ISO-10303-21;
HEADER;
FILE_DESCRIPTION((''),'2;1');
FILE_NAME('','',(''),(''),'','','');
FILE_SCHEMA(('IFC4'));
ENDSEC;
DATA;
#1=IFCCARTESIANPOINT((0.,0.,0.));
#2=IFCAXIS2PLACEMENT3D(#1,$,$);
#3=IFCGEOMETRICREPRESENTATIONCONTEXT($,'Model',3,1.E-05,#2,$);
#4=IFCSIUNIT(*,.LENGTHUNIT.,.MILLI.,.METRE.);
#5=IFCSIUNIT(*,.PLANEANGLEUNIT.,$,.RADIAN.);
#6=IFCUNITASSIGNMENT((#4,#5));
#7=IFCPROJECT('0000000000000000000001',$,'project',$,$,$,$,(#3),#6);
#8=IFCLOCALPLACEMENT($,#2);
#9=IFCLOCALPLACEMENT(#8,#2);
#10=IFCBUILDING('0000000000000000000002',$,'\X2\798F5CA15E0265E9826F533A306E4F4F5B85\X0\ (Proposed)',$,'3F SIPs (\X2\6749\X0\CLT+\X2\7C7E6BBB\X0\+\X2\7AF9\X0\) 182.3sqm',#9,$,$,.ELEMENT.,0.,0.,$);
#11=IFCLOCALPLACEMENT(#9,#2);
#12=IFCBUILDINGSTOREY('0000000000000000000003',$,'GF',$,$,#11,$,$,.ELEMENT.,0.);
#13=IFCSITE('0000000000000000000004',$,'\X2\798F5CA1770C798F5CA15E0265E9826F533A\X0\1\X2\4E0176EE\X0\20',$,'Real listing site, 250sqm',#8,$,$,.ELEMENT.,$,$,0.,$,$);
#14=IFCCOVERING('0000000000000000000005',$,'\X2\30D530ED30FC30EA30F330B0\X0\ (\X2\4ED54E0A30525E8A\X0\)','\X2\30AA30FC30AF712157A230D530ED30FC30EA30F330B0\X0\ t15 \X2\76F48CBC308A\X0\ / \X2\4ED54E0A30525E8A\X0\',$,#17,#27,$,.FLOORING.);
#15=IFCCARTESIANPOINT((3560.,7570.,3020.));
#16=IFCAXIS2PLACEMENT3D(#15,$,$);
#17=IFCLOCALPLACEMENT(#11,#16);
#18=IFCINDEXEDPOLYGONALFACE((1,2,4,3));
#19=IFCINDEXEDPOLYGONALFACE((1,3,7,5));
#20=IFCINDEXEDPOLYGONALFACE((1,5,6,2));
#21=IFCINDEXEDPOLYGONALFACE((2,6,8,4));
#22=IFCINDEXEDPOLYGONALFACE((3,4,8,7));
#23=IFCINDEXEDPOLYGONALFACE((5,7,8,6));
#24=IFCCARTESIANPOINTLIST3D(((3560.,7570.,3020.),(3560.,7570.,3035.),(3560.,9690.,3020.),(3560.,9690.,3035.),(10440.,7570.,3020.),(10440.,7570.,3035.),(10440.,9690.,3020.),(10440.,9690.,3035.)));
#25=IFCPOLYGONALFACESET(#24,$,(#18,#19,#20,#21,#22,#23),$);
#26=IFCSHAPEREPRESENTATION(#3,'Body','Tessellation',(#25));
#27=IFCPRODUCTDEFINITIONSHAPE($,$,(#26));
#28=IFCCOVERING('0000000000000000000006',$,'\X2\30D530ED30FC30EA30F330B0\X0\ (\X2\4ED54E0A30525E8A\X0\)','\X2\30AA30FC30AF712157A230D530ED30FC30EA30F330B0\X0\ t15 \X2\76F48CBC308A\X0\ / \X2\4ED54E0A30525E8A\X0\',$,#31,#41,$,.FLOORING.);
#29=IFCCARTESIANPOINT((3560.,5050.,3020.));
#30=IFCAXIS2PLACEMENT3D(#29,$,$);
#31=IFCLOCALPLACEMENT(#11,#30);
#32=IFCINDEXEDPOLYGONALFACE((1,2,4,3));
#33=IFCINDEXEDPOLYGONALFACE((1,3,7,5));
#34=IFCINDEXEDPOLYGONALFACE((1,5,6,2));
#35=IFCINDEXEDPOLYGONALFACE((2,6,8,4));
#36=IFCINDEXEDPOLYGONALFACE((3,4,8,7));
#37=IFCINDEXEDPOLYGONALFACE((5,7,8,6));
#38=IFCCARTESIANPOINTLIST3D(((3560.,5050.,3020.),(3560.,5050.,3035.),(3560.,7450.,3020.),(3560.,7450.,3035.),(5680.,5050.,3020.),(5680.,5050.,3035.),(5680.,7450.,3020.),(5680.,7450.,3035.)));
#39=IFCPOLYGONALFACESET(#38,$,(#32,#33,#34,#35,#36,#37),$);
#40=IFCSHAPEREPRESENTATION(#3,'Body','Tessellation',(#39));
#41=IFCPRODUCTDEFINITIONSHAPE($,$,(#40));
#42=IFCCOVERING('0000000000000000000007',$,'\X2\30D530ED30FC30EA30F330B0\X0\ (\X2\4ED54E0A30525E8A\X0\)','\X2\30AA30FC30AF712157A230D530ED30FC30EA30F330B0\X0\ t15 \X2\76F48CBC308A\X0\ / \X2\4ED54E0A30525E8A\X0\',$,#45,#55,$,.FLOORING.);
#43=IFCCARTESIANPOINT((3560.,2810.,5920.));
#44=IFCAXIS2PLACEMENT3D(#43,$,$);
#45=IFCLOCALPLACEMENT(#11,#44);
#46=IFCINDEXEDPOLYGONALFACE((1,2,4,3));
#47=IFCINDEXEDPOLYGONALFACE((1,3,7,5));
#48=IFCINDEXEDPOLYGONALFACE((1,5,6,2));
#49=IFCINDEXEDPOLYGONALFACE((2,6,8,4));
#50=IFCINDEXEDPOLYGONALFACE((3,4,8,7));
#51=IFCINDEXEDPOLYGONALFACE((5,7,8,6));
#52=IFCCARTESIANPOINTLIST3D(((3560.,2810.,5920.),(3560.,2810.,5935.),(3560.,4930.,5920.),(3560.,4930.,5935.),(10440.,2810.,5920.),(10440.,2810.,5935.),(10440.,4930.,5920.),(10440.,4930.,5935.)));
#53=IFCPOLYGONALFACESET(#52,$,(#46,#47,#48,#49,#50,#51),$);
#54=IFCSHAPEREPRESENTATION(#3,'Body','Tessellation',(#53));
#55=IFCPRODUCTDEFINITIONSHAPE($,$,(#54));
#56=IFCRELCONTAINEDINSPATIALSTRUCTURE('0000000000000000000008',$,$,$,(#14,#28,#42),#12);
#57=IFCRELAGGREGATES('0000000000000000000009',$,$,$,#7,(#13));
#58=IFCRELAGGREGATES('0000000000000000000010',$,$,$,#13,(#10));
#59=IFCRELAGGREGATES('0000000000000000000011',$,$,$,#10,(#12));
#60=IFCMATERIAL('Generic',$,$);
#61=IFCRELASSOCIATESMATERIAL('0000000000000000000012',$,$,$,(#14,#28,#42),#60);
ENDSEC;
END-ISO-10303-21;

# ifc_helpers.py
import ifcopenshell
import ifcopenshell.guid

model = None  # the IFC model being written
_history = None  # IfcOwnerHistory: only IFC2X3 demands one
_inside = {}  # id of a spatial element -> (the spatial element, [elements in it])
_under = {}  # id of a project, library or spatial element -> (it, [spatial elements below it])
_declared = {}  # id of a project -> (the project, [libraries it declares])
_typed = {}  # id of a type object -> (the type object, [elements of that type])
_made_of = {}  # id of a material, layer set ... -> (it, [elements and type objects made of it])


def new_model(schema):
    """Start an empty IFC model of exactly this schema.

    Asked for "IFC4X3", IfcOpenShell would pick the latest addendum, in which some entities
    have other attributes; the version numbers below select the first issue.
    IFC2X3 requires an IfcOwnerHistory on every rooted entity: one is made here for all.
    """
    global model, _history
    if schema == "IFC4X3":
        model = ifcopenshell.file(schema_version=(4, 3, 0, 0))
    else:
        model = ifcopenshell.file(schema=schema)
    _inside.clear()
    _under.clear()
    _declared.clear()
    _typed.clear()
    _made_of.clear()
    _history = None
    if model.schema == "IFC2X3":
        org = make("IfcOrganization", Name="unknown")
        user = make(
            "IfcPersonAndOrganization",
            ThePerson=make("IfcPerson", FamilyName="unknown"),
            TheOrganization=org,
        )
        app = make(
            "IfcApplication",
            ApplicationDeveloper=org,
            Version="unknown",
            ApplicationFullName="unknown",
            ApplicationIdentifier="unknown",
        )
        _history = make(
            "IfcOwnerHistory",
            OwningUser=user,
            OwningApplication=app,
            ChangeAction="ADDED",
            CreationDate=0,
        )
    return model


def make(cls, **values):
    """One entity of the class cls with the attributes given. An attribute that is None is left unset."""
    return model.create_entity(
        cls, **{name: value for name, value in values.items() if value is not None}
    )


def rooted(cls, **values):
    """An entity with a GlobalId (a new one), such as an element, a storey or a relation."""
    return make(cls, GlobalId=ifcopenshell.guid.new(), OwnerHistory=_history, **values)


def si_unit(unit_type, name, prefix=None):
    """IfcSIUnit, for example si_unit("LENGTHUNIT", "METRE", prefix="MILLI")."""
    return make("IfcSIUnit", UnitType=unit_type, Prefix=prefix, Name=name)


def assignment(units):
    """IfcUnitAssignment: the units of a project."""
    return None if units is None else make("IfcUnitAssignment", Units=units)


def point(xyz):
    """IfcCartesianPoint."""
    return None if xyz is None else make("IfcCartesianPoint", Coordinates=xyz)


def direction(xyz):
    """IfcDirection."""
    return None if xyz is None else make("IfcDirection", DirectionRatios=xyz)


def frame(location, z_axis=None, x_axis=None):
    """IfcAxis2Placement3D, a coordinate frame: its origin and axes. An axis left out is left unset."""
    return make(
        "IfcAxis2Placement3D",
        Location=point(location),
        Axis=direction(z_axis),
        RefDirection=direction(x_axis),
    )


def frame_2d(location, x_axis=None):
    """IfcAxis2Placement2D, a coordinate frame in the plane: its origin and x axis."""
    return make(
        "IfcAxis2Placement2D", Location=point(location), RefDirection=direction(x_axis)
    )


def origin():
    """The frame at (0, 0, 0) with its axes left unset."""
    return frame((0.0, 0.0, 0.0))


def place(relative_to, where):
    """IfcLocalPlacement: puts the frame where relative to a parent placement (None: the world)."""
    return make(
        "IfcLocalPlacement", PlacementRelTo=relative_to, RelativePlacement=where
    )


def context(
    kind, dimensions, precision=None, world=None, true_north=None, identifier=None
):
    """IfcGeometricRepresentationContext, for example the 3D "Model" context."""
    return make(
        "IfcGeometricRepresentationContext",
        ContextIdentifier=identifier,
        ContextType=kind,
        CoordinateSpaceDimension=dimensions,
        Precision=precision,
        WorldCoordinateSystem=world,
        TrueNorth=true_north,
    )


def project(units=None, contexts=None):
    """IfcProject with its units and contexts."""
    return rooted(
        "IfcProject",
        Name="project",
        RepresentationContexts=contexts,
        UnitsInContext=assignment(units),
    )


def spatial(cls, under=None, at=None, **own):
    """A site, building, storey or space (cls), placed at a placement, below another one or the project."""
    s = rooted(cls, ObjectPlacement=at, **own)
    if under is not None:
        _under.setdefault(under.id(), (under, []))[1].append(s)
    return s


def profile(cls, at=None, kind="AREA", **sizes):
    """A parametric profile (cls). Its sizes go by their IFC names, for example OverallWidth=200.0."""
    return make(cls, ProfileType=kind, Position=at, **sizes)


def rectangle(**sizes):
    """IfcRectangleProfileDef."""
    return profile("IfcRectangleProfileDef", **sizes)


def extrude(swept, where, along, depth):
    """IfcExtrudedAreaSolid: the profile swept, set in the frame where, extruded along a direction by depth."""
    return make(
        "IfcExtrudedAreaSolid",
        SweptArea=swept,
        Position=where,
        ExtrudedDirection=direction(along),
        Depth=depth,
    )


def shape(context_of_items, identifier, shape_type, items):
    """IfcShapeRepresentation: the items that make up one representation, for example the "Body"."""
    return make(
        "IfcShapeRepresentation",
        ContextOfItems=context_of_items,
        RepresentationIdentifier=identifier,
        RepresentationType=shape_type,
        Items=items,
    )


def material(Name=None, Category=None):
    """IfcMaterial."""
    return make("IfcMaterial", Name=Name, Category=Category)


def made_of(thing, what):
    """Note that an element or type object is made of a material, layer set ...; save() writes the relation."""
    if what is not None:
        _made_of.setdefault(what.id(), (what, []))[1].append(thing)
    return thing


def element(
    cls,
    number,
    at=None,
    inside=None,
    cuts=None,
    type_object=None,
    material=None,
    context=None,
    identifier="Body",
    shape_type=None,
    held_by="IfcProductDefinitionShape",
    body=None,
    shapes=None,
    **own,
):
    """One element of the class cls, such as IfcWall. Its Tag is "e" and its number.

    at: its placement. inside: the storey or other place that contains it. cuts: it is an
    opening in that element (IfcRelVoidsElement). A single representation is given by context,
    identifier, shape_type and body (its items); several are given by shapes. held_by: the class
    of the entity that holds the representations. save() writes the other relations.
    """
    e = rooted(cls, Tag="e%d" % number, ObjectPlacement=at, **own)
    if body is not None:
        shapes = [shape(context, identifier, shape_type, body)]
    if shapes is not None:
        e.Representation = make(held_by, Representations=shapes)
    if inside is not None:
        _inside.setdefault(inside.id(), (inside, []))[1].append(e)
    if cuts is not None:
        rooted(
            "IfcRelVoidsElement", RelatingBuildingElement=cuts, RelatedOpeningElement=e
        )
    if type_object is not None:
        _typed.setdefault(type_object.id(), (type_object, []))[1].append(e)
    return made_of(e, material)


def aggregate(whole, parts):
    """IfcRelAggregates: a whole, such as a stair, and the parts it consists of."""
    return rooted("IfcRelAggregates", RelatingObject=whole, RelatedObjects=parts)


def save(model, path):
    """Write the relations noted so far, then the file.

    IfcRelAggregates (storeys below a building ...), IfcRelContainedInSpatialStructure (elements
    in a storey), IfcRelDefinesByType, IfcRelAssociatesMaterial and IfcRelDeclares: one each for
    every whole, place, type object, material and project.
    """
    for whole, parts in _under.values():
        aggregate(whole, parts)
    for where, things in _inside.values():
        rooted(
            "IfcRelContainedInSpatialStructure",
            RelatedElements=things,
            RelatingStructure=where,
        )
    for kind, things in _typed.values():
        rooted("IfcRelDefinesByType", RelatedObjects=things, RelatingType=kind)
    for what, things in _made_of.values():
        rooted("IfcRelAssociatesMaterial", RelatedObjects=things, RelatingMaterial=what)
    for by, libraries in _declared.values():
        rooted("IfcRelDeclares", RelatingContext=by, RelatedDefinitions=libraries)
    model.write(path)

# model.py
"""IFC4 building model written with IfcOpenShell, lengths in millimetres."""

from ifc_helpers import new_model, si_unit, frame, frame_2d, origin, place, context, project, spatial, rectangle, extrude, material, element, save


model = new_model("IFC4")

# Units and contexts
model_context = context("Model", 3, precision=1e-05, world=origin())
ifc_project = project(units=[si_unit("LENGTHUNIT", "METRE", prefix="MILLI"), si_unit("PLANEANGLEUNIT", "RADIAN")], contexts=[model_context])

# Site, building, storey
site_placement = place(None, origin())
site = spatial("IfcSite", under=ifc_project, at=site_placement, Name="福岡県福岡市早良区1丁目20", ObjectType="Real listing site, 250sqm", CompositionType="ELEMENT", RefElevation=0.0)
building_placement = place(site_placement, origin())
building = spatial("IfcBuilding", under=site, at=building_placement, Name="福岡市早良区の住宅 (Proposed)", ObjectType="3F SIPs (杉CLT+籾殻+竹) 182.3sqm", CompositionType="ELEMENT", ElevationOfRefHeight=0.0, ElevationOfTerrain=0.0)
storey_placement = place(building_placement, origin())
storey = spatial("IfcBuildingStorey", under=building, at=storey_placement, Name="GF", CompositionType="ELEMENT", Elevation=0.0)

# Shared definitions
ifc_material_1 = material(Name="Generic")

# Coverings
covering_1_placement = place(storey_placement, frame((3560.0, 7570.0, 3020.0)))
element("IfcCovering", 1, at=covering_1_placement, inside=storey, material=ifc_material_1, Name="フローリング (仕上げ床)", Description="オーク無垢フローリング t15 直貼り / 仕上げ床", PredefinedType="FLOORING", context=model_context, shape_type="SweptSolid", body=[
    extrude(rectangle(XDim=6880.0, YDim=2120.0, at=frame_2d((3440.0, 1060.0))), frame((3560.0, 7570.0, 3020.0)), (0.0, 0.0, 1.0), 15.0),
])
covering_2_placement = place(storey_placement, frame((3560.0, 5050.0, 3020.0)))
element("IfcCovering", 2, at=covering_2_placement, inside=storey, material=ifc_material_1, Name="フローリング (仕上げ床)", Description="オーク無垢フローリング t15 直貼り / 仕上げ床", PredefinedType="FLOORING", context=model_context, shape_type="SweptSolid", body=[
    extrude(rectangle(XDim=2120.0, YDim=2400.0, at=frame_2d((1060.0, 1200.0))), frame((3560.0, 5050.0, 3020.0)), (0.0, 0.0, 1.0), 15.0),
])
covering_3_placement = place(storey_placement, frame((3560.0, 2810.0, 5920.0)))
element("IfcCovering", 3, at=covering_3_placement, inside=storey, material=ifc_material_1, Name="フローリング (仕上げ床)", Description="オーク無垢フローリング t15 直貼り / 仕上げ床", PredefinedType="FLOORING", context=model_context, shape_type="SweptSolid", body=[
    extrude(rectangle(XDim=6880.0, YDim=2120.0, at=frame_2d((3440.0, 1060.0))), frame((3560.0, 2810.0, 5920.0)), (0.0, 0.0, 1.0), 15.0),
])

save(model, "model.ifc")
